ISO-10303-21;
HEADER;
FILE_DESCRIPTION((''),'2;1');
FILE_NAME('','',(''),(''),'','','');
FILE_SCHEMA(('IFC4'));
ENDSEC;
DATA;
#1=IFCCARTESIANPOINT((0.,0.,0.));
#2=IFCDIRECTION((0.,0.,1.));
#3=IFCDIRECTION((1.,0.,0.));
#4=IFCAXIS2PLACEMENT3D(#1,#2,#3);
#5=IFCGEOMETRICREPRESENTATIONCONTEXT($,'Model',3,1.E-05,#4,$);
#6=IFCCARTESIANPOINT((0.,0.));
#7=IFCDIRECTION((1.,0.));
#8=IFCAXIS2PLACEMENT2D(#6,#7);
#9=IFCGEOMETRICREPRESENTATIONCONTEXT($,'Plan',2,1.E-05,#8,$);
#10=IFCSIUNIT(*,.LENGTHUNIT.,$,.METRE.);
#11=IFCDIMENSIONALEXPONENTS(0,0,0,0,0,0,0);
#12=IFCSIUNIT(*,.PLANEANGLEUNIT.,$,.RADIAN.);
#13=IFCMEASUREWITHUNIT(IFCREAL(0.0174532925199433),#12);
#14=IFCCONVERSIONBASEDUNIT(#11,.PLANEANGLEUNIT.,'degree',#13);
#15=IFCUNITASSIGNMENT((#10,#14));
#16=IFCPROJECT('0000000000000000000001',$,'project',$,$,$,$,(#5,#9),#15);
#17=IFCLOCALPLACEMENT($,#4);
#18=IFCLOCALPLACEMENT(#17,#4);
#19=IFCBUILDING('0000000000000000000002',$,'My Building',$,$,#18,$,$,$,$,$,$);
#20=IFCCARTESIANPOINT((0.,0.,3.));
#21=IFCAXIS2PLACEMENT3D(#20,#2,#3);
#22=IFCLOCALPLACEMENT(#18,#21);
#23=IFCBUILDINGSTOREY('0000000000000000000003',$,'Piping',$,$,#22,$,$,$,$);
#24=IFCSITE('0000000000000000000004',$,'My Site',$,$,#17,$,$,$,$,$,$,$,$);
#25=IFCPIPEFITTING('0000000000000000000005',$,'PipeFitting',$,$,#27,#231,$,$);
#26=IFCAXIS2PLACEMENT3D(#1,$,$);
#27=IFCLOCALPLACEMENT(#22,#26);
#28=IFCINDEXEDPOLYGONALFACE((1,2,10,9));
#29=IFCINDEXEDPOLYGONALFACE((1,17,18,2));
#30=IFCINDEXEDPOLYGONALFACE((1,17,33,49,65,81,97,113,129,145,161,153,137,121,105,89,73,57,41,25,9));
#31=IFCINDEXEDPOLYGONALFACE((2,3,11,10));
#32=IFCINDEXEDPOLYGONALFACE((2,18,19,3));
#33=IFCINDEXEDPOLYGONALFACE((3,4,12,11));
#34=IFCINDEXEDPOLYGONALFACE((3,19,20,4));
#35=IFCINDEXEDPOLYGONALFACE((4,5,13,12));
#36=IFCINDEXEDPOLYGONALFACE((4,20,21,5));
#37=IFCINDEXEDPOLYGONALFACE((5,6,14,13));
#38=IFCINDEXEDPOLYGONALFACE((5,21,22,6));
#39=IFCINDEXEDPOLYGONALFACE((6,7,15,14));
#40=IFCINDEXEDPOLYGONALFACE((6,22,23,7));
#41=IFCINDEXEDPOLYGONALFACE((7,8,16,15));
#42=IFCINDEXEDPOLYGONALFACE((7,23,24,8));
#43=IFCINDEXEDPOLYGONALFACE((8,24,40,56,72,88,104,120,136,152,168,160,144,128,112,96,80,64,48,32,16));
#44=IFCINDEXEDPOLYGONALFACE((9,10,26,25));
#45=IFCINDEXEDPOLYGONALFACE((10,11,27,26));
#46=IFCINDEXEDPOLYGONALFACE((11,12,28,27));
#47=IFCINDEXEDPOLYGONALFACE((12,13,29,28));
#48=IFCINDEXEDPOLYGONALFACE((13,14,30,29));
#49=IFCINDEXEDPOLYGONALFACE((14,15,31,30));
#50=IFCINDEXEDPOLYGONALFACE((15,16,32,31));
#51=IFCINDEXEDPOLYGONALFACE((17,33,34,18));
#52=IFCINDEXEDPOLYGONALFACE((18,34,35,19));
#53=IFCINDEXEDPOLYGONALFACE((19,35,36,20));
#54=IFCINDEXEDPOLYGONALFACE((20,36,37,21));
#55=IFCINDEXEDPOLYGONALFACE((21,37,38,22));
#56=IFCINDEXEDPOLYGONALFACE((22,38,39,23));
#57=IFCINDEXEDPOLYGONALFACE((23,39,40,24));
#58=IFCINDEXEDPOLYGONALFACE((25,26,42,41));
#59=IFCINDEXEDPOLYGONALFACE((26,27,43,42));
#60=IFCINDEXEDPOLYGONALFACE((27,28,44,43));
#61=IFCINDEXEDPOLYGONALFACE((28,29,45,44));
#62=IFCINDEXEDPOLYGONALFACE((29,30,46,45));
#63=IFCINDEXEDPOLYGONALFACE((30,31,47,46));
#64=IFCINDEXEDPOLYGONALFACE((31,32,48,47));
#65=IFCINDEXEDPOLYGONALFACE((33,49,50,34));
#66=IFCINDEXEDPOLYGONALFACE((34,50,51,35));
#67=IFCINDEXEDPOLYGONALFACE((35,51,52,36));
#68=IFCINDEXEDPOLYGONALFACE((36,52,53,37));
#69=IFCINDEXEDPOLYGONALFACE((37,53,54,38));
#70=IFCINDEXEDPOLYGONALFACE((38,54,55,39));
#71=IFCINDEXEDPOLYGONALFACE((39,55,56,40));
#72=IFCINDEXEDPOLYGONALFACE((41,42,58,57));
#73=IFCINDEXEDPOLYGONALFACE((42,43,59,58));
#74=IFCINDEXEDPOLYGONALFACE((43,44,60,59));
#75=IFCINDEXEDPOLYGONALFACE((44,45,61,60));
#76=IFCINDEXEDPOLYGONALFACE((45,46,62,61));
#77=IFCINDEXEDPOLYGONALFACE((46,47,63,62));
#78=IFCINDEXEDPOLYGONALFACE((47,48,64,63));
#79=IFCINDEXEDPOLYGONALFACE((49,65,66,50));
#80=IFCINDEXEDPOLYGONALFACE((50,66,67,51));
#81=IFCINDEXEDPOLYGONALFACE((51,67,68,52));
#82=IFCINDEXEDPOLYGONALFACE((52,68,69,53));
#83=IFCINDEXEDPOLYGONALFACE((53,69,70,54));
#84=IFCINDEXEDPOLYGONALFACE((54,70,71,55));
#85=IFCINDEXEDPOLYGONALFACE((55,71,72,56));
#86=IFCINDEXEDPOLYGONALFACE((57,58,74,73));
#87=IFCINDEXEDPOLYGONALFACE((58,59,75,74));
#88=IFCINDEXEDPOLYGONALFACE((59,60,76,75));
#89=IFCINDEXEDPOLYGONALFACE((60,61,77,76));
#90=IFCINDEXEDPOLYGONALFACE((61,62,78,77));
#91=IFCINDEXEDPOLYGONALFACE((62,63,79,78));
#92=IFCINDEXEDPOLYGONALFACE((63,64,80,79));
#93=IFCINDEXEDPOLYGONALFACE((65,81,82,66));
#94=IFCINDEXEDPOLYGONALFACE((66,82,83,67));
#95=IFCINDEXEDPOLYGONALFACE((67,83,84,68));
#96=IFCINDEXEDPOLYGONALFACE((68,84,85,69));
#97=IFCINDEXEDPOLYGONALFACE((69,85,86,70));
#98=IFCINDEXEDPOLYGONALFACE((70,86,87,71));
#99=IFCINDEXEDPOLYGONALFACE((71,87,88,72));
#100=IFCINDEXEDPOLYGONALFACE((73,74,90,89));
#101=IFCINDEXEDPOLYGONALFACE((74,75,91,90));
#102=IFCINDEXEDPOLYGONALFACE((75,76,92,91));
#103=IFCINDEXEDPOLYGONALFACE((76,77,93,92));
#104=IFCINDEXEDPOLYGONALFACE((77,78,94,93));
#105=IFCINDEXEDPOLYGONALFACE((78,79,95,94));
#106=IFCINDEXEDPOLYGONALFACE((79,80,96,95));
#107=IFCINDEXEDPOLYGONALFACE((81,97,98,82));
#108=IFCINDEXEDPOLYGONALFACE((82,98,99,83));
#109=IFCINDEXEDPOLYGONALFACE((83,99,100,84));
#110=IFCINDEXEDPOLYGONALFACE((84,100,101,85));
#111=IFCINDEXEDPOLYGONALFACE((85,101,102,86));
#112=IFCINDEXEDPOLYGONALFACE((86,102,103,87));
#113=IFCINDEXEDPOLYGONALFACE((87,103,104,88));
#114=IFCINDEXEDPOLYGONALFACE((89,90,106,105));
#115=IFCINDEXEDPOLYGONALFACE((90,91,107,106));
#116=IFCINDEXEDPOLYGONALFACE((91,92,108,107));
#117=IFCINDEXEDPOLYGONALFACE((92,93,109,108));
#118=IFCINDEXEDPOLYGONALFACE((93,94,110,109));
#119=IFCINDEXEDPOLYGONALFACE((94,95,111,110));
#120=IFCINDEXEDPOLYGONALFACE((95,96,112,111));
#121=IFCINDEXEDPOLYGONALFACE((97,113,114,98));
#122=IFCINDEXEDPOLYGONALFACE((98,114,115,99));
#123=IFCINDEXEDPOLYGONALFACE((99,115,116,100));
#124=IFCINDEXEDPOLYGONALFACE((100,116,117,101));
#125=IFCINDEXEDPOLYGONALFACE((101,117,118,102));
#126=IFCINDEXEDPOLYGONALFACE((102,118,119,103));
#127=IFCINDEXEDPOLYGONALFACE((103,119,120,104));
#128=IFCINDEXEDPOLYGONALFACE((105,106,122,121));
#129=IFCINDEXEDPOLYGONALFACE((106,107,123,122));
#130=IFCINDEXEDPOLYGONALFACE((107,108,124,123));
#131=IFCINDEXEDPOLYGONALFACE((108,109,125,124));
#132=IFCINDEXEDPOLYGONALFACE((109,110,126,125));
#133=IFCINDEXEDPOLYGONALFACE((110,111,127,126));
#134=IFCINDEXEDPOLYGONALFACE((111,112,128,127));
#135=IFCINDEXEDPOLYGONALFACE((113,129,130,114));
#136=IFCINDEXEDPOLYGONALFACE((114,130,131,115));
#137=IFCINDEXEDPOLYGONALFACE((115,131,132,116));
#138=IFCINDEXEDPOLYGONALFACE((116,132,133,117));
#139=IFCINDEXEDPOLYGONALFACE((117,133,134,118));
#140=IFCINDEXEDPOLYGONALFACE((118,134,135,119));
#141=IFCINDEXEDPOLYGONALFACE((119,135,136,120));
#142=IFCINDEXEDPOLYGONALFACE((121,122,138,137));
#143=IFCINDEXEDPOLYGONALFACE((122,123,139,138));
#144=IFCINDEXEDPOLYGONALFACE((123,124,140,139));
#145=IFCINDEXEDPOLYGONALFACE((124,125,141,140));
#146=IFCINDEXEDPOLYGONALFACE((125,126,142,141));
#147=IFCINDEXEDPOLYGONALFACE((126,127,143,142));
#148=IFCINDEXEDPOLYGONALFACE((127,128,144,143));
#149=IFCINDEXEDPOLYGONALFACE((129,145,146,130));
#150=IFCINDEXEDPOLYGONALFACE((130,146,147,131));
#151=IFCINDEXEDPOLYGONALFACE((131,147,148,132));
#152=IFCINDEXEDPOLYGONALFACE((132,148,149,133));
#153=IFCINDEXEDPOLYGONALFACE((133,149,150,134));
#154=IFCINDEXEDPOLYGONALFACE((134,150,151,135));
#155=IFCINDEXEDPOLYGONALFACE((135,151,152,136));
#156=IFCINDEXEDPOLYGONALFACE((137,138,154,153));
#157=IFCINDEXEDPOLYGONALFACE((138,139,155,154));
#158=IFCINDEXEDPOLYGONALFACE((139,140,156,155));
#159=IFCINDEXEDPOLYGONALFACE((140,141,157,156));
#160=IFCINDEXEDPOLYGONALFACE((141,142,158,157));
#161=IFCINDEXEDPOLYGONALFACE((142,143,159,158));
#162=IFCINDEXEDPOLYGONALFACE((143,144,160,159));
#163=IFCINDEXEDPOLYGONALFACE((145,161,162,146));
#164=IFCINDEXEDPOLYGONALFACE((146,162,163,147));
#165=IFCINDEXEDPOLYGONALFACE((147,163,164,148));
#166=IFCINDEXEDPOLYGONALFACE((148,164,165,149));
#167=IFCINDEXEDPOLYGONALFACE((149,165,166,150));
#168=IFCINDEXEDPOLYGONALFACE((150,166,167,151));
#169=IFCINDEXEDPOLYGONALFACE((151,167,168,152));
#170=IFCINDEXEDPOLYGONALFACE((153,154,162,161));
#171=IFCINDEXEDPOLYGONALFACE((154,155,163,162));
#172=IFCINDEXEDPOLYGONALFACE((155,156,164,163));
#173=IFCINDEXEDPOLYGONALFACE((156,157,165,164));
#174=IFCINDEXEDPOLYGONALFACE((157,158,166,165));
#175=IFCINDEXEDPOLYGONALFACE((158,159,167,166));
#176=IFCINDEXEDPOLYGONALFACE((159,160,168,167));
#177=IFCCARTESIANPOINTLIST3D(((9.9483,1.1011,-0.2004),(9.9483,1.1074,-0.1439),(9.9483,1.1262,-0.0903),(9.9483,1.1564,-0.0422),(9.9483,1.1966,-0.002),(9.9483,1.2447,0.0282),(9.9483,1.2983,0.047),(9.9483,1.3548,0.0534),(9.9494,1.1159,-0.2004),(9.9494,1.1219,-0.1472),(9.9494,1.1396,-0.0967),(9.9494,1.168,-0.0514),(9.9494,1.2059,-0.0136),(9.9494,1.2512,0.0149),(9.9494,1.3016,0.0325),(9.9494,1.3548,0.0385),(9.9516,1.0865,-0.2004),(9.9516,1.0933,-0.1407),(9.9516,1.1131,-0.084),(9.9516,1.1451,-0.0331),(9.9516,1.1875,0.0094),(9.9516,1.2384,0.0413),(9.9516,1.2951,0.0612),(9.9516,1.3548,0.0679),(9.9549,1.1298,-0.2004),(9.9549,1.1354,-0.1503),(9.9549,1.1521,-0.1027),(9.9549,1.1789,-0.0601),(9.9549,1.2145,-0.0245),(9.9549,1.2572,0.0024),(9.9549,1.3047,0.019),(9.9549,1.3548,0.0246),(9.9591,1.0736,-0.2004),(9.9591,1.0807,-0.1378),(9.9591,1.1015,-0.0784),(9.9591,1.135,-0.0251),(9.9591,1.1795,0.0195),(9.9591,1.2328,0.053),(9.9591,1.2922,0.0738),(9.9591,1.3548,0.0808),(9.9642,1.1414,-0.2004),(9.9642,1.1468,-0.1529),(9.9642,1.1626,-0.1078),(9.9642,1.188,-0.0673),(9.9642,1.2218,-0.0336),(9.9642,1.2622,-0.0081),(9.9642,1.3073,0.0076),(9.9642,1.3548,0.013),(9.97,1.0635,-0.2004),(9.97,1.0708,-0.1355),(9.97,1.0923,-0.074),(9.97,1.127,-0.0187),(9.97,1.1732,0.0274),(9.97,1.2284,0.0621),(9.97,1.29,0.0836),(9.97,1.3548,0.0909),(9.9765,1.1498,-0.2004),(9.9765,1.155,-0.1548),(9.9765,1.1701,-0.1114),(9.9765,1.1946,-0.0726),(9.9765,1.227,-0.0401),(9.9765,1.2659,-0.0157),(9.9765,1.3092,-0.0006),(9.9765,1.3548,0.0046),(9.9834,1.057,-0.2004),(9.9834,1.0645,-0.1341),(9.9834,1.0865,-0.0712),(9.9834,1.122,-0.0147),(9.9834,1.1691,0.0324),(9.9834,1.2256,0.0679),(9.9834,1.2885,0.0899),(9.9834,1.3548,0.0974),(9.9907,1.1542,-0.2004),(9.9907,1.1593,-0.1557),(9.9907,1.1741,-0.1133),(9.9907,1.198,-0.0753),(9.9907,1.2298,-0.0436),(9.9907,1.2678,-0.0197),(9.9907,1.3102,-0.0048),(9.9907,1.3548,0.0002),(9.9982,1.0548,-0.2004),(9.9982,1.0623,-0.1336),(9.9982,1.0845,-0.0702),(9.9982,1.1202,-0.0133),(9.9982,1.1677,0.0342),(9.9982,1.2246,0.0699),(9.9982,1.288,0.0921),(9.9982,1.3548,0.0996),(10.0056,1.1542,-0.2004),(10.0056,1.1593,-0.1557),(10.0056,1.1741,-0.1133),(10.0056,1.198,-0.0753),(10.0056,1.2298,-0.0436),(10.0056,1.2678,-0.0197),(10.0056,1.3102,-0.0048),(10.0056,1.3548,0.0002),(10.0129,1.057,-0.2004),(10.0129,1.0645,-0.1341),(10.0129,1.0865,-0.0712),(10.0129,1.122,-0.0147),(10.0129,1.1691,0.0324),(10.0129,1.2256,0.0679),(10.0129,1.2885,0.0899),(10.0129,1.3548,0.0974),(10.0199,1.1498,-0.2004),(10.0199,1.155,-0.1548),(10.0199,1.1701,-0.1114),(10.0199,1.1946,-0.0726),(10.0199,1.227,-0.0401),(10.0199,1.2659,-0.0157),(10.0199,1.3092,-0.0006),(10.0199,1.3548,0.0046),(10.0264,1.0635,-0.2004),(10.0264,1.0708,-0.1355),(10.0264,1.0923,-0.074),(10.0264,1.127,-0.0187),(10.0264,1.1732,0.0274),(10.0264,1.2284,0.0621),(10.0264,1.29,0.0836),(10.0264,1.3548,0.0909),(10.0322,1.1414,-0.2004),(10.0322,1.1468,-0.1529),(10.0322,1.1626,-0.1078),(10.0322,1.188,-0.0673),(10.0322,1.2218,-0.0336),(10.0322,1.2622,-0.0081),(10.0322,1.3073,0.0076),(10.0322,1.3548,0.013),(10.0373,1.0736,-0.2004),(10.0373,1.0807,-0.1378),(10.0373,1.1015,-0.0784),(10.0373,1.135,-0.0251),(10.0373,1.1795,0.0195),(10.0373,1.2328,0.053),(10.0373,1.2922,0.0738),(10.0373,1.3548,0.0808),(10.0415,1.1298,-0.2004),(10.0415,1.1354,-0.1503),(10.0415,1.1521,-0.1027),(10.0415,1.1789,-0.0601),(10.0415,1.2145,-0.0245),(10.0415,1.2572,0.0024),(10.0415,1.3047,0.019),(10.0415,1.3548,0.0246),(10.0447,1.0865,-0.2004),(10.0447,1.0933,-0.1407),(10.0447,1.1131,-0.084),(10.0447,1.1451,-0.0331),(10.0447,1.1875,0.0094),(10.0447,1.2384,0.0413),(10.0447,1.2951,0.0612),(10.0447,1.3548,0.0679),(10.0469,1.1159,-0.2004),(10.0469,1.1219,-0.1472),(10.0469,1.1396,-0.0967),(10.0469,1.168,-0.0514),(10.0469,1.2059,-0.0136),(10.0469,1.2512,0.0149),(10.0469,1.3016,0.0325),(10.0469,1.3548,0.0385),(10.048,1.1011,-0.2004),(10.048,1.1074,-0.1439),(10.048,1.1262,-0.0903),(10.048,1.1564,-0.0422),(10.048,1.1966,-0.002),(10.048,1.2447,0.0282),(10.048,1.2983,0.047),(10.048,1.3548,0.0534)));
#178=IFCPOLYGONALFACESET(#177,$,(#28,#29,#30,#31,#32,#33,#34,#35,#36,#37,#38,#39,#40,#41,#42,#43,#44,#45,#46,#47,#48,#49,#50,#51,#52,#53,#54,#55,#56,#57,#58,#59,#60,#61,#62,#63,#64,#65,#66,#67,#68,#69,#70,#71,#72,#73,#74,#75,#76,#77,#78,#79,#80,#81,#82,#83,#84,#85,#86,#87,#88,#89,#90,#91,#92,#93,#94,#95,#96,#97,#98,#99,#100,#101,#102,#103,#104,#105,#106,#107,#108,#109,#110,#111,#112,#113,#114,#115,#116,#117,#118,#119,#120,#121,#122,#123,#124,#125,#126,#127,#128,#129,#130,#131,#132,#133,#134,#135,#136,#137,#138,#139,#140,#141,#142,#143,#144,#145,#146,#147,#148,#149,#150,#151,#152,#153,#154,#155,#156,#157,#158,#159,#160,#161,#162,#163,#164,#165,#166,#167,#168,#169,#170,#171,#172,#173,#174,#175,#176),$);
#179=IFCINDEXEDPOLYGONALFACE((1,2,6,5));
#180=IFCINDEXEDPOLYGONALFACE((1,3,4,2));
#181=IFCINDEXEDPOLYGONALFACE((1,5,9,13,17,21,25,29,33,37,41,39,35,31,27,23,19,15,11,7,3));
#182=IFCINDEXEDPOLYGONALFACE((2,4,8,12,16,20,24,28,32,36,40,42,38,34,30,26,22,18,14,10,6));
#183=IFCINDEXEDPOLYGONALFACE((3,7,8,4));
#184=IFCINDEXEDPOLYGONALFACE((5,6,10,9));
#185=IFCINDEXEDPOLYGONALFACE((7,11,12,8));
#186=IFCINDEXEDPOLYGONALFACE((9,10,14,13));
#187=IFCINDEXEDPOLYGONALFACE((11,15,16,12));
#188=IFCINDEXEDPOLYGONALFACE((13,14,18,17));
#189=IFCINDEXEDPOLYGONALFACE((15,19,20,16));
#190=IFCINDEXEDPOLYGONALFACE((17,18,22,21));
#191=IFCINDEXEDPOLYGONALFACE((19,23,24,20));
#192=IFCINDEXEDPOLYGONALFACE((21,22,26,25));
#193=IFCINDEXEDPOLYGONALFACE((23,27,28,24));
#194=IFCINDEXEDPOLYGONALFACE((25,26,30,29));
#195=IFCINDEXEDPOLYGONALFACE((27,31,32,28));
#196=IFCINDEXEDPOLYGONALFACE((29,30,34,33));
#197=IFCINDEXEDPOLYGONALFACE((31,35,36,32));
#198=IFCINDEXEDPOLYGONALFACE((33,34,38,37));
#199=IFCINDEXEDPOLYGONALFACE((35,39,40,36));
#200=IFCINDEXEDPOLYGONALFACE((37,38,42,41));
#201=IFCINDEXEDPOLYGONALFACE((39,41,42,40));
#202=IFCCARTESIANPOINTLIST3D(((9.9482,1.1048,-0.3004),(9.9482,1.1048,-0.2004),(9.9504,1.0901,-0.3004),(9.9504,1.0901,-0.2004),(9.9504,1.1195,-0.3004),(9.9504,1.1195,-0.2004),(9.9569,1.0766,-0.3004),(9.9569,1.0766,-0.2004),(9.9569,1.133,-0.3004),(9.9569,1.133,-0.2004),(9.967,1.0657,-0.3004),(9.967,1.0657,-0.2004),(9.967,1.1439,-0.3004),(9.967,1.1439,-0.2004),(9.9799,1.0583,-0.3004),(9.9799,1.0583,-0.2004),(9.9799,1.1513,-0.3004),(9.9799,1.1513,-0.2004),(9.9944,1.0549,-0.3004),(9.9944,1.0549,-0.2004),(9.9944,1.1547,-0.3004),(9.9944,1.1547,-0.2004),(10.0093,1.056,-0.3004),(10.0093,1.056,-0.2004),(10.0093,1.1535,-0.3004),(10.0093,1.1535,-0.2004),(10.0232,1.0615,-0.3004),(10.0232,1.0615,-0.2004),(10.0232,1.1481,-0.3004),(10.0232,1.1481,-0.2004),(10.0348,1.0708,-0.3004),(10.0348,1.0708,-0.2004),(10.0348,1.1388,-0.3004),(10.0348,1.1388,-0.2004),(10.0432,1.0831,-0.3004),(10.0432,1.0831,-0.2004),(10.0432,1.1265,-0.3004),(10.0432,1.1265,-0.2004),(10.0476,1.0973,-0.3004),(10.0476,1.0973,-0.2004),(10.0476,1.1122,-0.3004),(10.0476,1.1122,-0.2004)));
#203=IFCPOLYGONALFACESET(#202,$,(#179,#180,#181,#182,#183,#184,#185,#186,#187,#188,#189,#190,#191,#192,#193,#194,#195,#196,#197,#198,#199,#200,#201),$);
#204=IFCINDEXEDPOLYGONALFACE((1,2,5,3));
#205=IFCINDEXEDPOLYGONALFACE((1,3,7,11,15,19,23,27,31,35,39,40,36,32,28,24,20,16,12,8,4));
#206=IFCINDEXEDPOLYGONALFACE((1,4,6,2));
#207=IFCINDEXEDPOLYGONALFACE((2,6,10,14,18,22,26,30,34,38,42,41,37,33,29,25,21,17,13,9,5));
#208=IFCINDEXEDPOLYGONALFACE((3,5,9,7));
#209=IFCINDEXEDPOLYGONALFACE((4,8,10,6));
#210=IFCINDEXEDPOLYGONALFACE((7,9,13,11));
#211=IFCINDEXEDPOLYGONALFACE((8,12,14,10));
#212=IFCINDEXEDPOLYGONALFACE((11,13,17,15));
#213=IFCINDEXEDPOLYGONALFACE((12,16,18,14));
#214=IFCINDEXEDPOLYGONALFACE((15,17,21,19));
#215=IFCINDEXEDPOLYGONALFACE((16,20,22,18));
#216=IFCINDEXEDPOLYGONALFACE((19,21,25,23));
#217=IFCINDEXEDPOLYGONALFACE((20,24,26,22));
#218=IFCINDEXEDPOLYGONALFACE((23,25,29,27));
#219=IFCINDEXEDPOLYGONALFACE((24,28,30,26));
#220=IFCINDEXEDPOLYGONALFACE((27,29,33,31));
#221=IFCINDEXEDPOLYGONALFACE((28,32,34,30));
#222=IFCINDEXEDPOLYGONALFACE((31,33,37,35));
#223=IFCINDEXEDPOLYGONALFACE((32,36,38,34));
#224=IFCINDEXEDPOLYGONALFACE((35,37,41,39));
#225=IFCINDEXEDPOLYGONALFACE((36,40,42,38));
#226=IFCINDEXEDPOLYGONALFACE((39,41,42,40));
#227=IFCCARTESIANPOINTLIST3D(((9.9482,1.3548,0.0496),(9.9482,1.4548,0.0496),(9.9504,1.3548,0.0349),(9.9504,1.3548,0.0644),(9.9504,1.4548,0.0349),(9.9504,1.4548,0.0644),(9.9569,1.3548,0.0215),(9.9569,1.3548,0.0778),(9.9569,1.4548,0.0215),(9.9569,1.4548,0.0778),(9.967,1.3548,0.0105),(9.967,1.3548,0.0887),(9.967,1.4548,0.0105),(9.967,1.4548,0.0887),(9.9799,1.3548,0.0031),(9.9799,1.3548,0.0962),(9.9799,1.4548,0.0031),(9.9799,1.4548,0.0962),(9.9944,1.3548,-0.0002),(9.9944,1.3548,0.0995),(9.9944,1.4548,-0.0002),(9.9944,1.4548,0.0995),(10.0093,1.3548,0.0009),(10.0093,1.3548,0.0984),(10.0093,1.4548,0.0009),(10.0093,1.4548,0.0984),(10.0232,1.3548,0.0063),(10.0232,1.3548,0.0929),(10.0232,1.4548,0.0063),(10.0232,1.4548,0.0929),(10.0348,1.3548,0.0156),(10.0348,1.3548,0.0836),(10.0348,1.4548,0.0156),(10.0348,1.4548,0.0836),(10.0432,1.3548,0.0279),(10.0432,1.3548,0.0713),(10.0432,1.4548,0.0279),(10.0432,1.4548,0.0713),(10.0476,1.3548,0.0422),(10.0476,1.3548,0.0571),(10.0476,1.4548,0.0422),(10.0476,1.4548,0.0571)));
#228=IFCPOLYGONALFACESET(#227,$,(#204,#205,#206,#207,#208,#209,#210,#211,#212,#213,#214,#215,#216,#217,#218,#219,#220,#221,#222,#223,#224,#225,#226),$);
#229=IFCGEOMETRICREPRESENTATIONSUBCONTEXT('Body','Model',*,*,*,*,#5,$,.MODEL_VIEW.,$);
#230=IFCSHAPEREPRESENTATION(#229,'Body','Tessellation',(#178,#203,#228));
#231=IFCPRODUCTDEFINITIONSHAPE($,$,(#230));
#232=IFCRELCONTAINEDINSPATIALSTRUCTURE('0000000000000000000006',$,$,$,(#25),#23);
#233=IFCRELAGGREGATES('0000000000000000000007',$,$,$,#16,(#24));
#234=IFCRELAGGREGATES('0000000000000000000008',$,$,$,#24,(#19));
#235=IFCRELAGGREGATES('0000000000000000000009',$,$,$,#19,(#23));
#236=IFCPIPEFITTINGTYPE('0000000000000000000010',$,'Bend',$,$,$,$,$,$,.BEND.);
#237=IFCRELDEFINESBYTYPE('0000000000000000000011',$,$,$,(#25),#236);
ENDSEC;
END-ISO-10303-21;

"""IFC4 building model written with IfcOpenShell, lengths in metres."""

from ifc_helpers import new_model, entity, si_unit, converted_unit, frame, origin_with_axes, origin_2d_with_axis, place, context, subcontext, project, spatial, circle, extrude, source, transform, mapped, type_object, type_shapes, element, save


model = new_model("IFC4")

# Units and contexts
model_context = context("Model", 3, precision=1e-05, world=origin_with_axes())
plan_context = context("Plan", 2, precision=1e-05, world=origin_2d_with_axis())
body_context = subcontext(model_context, "Body", "Model", "MODEL_VIEW")
ifc_project = project(units=[si_unit("LENGTHUNIT", "METRE"), converted_unit("PLANEANGLEUNIT", "degree", entity("IfcReal", 0.0174532925199433), si_unit("PLANEANGLEUNIT", "RADIAN"), dimensions=[0, 0, 0, 0, 0, 0, 0])], contexts=[model_context, plan_context])

# Site, building, storey
site_placement = place(None, origin_with_axes())
site = spatial("IfcSite", under=ifc_project, at=site_placement, Name="My Site")
building_placement = place(site_placement, origin_with_axes())
building = spatial("IfcBuilding", under=site, at=building_placement, Name="My Building")
storey_placement = place(building_placement, frame((0.0, 0.0, 3.0), z_axis=(0.0, 0.0, 1.0), x_axis=(1.0, 0.0, 0.0)))
storey = spatial("IfcBuildingStorey", under=building, at=storey_placement, Name="Piping")

# Pipe fitting
pipe_fitting_type = type_object("IfcPipeFittingType", Name="Bend", PredefinedType="BEND")
shared_shape = source(origin_with_axes(), body_context, "Body", "SolidModel", [
    entity("IfcSweptDiskSolid", entity("IfcIndexedPolyCurve", entity("IfcCartesianPointList3D", [[0.0, 0.0, -0.1], [0.0, 0.0732, -0.2768], [0.0, 0.25, -0.35]]), [entity("IfcArcIndex", [1, 2, 3])]), 0.05),
    extrude(circle(Radius=0.05), origin_with_axes(), (0.0, 0.0, -1.0), 0.1),
    extrude(circle(Radius=0.05), frame((0.0, 0.25, -0.35), z_axis=(0.0, 1.0, 0.000007), x_axis=(1.0, 0.0, 0.0)), (0.0, 0.0, 1.0), 0.1),
])
type_shapes(pipe_fitting_type, [shared_shape])
for number, where, z_axis, x_axis, name in (
    (1, (9.9982, 1.1048, -0.3004), (0.0, 0.0, -1.0), (-1.0, 0.0, 0.0), "PipeFitting"),
):
    element("IfcPipeFitting", number, at=place(storey_placement, frame(where, z_axis=z_axis, x_axis=x_axis)), inside=storey, type_object=pipe_fitting_type, Name=name, context=body_context, shape_type="MappedRepresentation", body=[
        mapped(shared_shape, transform((0.0, 0.0, 0.0), x_axis=(1.0, 0.0, 0.0), y_axis=(0.0, 1.0, 0.0), z_axis=(0.0, 0.0, 1.0), scale=1.0)),
    ])

save(model, "model.ifc")
